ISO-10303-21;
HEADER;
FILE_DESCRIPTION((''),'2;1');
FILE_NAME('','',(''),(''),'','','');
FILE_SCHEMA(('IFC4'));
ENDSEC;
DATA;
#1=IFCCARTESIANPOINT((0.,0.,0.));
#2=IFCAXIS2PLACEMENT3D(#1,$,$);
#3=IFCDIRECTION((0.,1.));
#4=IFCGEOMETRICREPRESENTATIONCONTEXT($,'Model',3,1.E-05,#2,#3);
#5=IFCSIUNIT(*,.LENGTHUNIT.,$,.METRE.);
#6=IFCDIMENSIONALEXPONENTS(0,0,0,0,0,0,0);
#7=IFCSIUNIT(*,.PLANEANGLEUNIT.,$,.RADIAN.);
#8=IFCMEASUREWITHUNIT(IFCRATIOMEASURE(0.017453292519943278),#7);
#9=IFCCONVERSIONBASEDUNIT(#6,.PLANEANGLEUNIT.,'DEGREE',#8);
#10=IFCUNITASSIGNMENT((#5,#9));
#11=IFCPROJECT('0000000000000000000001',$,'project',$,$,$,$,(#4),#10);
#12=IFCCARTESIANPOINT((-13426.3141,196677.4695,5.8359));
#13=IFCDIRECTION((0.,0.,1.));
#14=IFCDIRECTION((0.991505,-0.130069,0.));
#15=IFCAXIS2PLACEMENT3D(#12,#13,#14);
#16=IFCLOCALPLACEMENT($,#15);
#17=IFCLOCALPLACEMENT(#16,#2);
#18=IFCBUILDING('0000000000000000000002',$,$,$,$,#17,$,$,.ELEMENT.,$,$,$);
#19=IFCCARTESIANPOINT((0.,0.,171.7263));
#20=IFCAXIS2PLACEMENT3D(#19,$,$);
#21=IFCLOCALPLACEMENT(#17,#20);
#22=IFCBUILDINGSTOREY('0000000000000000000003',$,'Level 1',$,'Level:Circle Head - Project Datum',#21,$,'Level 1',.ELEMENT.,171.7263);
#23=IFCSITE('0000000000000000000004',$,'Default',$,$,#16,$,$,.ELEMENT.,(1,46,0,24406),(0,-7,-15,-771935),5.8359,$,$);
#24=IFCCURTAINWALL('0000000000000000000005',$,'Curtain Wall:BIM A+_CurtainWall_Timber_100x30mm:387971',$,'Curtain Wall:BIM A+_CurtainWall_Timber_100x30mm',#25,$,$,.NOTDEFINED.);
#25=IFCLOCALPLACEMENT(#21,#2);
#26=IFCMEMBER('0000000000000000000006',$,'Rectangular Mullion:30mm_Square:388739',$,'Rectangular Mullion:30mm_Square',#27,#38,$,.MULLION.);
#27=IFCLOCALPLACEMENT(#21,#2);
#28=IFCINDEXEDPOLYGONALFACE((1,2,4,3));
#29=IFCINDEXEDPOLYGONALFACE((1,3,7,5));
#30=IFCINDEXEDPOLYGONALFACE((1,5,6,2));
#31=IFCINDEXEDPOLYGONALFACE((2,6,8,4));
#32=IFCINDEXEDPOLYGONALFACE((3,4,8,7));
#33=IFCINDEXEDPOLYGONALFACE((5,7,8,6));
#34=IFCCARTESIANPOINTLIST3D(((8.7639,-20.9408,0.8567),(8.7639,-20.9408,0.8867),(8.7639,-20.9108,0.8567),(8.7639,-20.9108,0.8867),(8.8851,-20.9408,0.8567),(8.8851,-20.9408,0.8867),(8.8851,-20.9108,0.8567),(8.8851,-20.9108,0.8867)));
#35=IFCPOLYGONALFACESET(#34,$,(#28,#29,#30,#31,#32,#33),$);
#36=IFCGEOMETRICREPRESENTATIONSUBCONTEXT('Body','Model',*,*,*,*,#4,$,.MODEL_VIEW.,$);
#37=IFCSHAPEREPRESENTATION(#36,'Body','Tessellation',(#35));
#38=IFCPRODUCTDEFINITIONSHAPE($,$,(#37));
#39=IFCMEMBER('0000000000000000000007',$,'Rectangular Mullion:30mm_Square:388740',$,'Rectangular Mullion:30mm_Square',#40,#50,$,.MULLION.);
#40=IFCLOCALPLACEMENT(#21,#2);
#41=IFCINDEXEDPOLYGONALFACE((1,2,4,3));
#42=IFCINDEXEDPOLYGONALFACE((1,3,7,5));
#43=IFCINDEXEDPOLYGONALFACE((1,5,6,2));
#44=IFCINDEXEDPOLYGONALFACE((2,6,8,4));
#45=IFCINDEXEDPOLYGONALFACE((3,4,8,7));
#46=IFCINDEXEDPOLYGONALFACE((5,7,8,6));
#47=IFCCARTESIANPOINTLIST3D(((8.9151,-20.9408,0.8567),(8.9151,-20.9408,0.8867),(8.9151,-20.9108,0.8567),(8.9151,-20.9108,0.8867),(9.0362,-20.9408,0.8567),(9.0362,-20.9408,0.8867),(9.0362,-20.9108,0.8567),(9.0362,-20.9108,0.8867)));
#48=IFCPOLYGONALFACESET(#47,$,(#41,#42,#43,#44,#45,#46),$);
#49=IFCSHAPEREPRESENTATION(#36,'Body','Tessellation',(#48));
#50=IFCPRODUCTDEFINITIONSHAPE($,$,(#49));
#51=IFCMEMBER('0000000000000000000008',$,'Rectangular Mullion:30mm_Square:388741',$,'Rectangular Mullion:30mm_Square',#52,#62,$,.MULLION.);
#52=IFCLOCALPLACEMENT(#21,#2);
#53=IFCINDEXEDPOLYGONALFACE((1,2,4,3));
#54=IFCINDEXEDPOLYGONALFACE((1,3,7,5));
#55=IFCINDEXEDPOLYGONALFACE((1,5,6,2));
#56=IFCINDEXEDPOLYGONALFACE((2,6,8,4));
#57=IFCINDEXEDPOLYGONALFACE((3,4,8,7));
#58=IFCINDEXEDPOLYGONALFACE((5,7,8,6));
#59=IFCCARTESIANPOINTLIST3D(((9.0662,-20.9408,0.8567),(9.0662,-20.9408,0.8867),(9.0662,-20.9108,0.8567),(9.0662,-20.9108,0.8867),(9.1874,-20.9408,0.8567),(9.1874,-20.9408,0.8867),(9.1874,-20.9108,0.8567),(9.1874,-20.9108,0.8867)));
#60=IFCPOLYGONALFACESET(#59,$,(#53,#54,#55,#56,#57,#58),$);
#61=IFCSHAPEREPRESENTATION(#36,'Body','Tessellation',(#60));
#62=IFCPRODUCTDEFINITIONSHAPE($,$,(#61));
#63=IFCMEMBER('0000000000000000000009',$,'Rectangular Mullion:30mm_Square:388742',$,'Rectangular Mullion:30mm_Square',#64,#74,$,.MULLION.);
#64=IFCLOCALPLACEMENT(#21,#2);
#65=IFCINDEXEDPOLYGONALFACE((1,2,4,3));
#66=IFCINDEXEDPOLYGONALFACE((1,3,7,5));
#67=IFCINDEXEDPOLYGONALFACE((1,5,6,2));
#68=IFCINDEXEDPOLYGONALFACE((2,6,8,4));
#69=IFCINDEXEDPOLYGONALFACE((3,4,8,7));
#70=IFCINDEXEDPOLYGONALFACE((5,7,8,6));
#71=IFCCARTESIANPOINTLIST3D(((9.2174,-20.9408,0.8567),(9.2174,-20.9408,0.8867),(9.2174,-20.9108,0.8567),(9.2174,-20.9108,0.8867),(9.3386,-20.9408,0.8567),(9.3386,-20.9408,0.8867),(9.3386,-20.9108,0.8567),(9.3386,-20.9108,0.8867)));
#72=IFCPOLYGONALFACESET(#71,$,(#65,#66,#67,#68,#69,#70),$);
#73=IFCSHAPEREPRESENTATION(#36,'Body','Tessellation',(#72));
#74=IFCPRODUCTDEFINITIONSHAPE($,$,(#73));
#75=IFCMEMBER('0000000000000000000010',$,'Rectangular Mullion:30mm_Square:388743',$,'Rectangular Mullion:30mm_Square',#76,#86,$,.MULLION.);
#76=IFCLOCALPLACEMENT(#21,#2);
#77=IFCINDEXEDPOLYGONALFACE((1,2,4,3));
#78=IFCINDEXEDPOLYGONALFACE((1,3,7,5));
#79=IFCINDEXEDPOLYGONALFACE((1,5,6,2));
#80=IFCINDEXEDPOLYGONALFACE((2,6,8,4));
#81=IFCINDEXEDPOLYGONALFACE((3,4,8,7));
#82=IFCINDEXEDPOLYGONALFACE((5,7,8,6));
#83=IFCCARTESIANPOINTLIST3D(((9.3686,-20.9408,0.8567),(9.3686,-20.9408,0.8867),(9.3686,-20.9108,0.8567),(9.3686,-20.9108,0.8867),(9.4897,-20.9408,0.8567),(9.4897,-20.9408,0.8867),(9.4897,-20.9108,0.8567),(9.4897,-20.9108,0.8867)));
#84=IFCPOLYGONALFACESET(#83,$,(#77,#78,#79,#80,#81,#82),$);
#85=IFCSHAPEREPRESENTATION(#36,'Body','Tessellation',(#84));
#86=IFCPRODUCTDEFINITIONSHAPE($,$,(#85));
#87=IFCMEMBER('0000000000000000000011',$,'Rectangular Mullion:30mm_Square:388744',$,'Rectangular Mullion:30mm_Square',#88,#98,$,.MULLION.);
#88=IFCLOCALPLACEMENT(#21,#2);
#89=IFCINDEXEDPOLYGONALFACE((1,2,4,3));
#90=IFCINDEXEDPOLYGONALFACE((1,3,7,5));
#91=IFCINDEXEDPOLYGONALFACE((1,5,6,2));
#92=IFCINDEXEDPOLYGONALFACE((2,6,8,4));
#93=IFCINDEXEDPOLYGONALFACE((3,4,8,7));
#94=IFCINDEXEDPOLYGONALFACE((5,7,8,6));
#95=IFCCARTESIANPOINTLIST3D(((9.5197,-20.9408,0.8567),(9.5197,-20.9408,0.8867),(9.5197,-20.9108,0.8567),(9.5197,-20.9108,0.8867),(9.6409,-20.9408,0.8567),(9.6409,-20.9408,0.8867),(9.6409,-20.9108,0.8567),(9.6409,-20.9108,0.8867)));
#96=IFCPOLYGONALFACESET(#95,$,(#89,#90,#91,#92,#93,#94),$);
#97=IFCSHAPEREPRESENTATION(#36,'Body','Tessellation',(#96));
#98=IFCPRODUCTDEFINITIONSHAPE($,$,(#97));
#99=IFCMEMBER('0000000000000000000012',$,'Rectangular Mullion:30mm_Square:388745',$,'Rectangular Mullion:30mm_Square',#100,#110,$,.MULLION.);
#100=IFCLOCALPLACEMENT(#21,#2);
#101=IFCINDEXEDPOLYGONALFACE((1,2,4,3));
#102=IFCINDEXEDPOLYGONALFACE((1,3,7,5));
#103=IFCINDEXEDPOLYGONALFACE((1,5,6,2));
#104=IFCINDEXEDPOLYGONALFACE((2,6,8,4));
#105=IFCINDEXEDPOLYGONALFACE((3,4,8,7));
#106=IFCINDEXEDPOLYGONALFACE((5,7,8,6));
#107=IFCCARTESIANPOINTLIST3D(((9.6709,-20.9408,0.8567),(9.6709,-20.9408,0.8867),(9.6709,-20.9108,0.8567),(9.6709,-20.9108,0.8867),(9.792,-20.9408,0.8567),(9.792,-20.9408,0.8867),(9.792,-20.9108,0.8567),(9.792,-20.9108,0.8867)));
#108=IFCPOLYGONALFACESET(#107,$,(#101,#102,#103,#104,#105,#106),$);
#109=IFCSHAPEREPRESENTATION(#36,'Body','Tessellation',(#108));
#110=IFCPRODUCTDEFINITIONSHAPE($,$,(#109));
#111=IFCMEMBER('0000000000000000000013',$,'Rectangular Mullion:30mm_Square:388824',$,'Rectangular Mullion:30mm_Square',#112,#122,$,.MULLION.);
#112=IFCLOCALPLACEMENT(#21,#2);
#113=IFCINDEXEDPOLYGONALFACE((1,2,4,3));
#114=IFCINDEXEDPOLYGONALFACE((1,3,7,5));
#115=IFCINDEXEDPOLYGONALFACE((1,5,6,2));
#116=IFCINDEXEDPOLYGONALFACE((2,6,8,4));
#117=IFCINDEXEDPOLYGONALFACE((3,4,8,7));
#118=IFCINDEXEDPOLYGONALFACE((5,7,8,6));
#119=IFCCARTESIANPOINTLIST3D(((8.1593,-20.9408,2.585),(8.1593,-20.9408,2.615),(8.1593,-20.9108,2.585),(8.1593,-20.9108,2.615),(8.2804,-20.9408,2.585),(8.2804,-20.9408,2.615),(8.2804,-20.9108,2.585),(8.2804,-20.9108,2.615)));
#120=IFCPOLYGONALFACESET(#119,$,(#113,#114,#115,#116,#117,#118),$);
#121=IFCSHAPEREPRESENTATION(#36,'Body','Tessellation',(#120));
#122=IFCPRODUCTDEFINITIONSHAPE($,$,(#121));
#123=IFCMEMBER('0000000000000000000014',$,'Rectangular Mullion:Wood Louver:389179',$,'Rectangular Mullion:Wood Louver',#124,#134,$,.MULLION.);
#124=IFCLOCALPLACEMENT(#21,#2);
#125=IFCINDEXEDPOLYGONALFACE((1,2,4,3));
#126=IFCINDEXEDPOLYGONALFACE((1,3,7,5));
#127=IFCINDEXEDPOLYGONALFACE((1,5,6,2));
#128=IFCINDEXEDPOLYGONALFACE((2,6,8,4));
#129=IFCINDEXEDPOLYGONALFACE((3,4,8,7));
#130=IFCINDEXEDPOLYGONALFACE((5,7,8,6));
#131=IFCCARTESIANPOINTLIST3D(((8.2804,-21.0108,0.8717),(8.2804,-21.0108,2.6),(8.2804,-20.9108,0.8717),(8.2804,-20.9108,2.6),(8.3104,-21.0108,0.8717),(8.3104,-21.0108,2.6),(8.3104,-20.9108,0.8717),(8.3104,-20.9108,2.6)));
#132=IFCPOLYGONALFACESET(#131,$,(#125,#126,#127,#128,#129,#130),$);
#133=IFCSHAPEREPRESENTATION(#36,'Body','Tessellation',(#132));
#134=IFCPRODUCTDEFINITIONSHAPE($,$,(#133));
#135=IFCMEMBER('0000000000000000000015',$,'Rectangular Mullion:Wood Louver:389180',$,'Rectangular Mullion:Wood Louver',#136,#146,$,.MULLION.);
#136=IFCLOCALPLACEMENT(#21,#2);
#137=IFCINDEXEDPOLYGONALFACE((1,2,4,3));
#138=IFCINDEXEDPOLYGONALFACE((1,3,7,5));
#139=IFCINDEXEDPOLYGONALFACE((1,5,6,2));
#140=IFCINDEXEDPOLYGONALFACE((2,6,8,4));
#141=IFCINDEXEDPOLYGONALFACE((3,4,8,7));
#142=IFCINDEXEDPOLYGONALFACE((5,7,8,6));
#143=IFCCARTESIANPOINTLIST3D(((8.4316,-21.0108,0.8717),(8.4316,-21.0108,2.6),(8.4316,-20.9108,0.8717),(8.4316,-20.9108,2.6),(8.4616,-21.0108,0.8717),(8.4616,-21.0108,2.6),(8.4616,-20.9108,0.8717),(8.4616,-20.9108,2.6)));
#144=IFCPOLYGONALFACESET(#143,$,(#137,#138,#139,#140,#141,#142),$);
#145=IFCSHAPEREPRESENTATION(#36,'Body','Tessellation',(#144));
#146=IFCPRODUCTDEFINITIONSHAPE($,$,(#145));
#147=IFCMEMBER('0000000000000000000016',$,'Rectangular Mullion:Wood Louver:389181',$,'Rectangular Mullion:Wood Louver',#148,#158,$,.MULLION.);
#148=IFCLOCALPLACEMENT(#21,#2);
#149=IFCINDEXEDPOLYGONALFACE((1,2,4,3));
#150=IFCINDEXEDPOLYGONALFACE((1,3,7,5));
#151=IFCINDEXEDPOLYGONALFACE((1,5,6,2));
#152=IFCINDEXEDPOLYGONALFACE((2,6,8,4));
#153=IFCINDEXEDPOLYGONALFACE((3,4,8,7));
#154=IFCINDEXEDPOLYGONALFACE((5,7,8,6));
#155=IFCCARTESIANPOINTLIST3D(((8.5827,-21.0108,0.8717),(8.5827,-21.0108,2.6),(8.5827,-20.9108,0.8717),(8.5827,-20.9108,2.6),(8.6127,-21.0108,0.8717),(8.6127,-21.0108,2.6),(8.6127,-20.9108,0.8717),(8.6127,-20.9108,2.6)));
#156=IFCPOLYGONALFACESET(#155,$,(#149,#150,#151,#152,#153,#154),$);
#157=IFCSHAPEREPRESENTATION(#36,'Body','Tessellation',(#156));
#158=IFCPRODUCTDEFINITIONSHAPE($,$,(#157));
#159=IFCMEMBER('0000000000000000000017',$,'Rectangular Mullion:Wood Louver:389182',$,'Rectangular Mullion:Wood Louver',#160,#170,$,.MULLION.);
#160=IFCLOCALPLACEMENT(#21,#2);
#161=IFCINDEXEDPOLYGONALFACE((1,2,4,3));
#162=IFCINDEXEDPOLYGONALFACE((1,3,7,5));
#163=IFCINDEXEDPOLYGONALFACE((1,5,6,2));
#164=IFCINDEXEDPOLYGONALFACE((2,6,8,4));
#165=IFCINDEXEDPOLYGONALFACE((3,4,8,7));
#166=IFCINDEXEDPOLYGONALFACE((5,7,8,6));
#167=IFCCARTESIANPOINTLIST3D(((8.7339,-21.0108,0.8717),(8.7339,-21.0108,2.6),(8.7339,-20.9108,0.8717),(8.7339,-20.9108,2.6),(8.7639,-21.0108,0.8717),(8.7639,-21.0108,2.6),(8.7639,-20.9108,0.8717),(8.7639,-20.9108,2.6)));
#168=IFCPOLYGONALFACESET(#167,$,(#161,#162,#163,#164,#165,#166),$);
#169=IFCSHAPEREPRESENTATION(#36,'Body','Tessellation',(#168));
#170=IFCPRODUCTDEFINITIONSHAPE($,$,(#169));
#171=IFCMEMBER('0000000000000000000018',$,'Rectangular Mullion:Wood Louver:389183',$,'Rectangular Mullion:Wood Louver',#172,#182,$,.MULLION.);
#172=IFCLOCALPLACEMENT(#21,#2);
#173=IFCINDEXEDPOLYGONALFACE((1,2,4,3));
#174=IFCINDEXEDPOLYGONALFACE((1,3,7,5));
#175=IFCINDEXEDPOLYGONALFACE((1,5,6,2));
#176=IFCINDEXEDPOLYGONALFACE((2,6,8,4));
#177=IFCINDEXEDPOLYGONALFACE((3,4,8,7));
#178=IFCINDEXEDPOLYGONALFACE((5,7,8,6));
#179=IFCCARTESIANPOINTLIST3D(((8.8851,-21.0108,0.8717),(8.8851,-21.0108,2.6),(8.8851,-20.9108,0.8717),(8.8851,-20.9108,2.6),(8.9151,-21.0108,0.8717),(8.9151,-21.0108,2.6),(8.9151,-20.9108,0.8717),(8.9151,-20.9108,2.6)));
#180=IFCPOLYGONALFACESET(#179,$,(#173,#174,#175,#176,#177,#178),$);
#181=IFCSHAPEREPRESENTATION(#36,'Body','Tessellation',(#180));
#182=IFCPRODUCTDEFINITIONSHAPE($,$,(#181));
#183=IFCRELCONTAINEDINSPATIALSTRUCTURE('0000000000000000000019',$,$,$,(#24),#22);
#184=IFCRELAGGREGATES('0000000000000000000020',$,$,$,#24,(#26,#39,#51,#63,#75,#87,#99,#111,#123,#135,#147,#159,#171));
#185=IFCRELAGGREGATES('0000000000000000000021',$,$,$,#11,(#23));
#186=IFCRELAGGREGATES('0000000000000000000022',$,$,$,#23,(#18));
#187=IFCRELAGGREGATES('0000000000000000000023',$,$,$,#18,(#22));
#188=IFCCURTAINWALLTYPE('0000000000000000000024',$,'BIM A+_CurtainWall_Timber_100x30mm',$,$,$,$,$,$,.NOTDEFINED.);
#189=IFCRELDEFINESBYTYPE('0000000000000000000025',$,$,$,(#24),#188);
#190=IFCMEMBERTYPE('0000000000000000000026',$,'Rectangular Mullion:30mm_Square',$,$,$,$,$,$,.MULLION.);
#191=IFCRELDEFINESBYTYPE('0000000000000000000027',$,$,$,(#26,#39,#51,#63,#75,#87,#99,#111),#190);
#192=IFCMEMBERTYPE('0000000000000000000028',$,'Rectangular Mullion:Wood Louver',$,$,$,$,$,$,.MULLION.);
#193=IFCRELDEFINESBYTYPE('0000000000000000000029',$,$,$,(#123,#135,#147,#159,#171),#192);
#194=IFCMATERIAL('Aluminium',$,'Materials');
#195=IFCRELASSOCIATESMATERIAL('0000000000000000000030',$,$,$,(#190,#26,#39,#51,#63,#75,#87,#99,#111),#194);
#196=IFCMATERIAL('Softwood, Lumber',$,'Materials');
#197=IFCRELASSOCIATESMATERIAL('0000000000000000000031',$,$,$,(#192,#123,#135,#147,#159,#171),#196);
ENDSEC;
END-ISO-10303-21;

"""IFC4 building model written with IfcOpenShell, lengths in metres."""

from ifc_helpers import new_model, entity, si_unit, converted_unit, direction, frame, origin, place, context, subcontext, project, spatial, indexed_curve, outline, extrude, source, transform, mapped, material, type_object, type_shapes, element, aggregate, save


model = new_model("IFC4")

# Units and contexts
model_context = context("Model", 3, precision=1e-05, world=origin(), true_north=direction((0.0, 1.0)))
body_context = subcontext(model_context, "Body", "Model", "MODEL_VIEW")
ifc_project = project(units=[si_unit("LENGTHUNIT", "METRE"), converted_unit("PLANEANGLEUNIT", "DEGREE", entity("IfcRatioMeasure", 0.017453292519943278), si_unit("PLANEANGLEUNIT", "RADIAN"), dimensions=[0, 0, 0, 0, 0, 0, 0])], contexts=[model_context])

# Site, building, storey
site_placement = place(None, frame((-13426.3141, 196677.4695, 5.8359), z_axis=(0.0, 0.0, 1.0), x_axis=(0.991505, -0.130069, 0.0)))
site = spatial("IfcSite", under=ifc_project, at=site_placement, Name="Default", CompositionType="ELEMENT", RefLatitude=(1, 46, 0, 24406), RefLongitude=(0, -7, -15, -771935), RefElevation=5.8359)
building_placement = place(site_placement, origin())
building = spatial("IfcBuilding", under=site, at=building_placement, CompositionType="ELEMENT")
storey_placement = place(building_placement, frame((0.0, 0.0, 171.7263)))
storey = spatial("IfcBuildingStorey", under=building, at=storey_placement, Name="Level 1", ObjectType="Level:Circle Head - Project Datum", LongName="Level 1", CompositionType="ELEMENT", Elevation=171.7263)

# Shared definitions
ifc_material_1 = material(Name="Aluminium", Category="Materials")

# Curtain wall, members
curtain_wall_type_1 = type_object("IfcCurtainWallType", Name="BIM A+_CurtainWall_Timber_100x30mm", PredefinedType="NOTDEFINED")
curtain_wall_1_placement = place(storey_placement, frame((0.0, 0.0, -171.7263)))
curtain_wall_1 = element("IfcCurtainWall", 1, at=curtain_wall_1_placement, inside=storey, type_object=curtain_wall_type_1, Name="Curtain Wall:BIM A+_CurtainWall_Timber_100x30mm:387971", ObjectType="Curtain Wall:BIM A+_CurtainWall_Timber_100x30mm", PredefinedType="NOTDEFINED")
member_type_1 = type_object("IfcMemberType", Name="Rectangular Mullion:30mm_Square", PredefinedType="MULLION", material=ifc_material_1)
shared_shape_1 = source(origin(), body_context, "Body", "SweptSolid", [
    extrude(outline(indexed_curve([(-0.015, -0.015), (0.015, -0.015), (0.015, 0.015), (-0.015, 0.015), (-0.015, -0.015)], self_intersect=False)), frame((0.0, 0.0, -0.1212), z_axis=(0.0, 0.0, 1.0), x_axis=(0.0, -1.0, 0.0)), (0.0, 0.0, 1.0), 0.1212),
])
type_shapes(member_type_1, [shared_shape_1])
member_1_placement = place(curtain_wall_1_placement, frame((8.8851, -20.9258, 172.598), z_axis=(1.0, 0.0, 0.0), x_axis=(0.0, 0.0, 1.0)))
member_1 = element("IfcMember", 2, at=member_1_placement, type_object=member_type_1, material=ifc_material_1, Name="Rectangular Mullion:30mm_Square:388739", ObjectType="Rectangular Mullion:30mm_Square", PredefinedType="MULLION", context=body_context, shape_type="MappedRepresentation", body=[
    mapped(shared_shape_1, transform((0.0, 0.0, 0.0), scale=1.0)),
])
member_2_placement = place(curtain_wall_1_placement, frame((9.0362, -20.9258, 172.598), z_axis=(1.0, 0.0, 0.0), x_axis=(0.0, 0.0, 1.0)))
member_2 = element("IfcMember", 3, at=member_2_placement, type_object=member_type_1, material=ifc_material_1, Name="Rectangular Mullion:30mm_Square:388740", ObjectType="Rectangular Mullion:30mm_Square", PredefinedType="MULLION", context=body_context, shape_type="MappedRepresentation", body=[
    mapped(shared_shape_1, transform((0.0, 0.0, 0.0), scale=1.0)),
])
member_3_placement = place(curtain_wall_1_placement, frame((9.1874, -20.9258, 172.598), z_axis=(1.0, 0.0, 0.0), x_axis=(0.0, 0.0, 1.0)))
member_3 = element("IfcMember", 4, at=member_3_placement, type_object=member_type_1, material=ifc_material_1, Name="Rectangular Mullion:30mm_Square:388741", ObjectType="Rectangular Mullion:30mm_Square", PredefinedType="MULLION", context=body_context, shape_type="MappedRepresentation", body=[
    mapped(shared_shape_1, transform((0.0, 0.0, 0.0), scale=1.0)),
])
member_4_placement = place(curtain_wall_1_placement, frame((9.3386, -20.9258, 172.598), z_axis=(1.0, 0.0, 0.0), x_axis=(0.0, 0.0, 1.0)))
member_4 = element("IfcMember", 5, at=member_4_placement, type_object=member_type_1, material=ifc_material_1, Name="Rectangular Mullion:30mm_Square:388742", ObjectType="Rectangular Mullion:30mm_Square", PredefinedType="MULLION", context=body_context, shape_type="MappedRepresentation", body=[
    mapped(shared_shape_1, transform((0.0, 0.0, 0.0), scale=1.0)),
])
member_5_placement = place(curtain_wall_1_placement, frame((9.4897, -20.9258, 172.598), z_axis=(1.0, 0.0, 0.0), x_axis=(0.0, 0.0, 1.0)))
member_5 = element("IfcMember", 6, at=member_5_placement, type_object=member_type_1, material=ifc_material_1, Name="Rectangular Mullion:30mm_Square:388743", ObjectType="Rectangular Mullion:30mm_Square", PredefinedType="MULLION", context=body_context, shape_type="MappedRepresentation", body=[
    mapped(shared_shape_1, transform((0.0, 0.0, 0.0), scale=1.0)),
])
member_6_placement = place(curtain_wall_1_placement, frame((9.6409, -20.9258, 172.598), z_axis=(1.0, 0.0, 0.0), x_axis=(0.0, 0.0, 1.0)))
member_6 = element("IfcMember", 7, at=member_6_placement, type_object=member_type_1, material=ifc_material_1, Name="Rectangular Mullion:30mm_Square:388744", ObjectType="Rectangular Mullion:30mm_Square", PredefinedType="MULLION", context=body_context, shape_type="MappedRepresentation", body=[
    mapped(shared_shape_1, transform((0.0, 0.0, 0.0), scale=1.0)),
])
member_7_placement = place(curtain_wall_1_placement, frame((9.792, -20.9258, 172.598), z_axis=(1.0, 0.0, 0.0), x_axis=(0.0, 0.0, 1.0)))
member_7 = element("IfcMember", 8, at=member_7_placement, type_object=member_type_1, material=ifc_material_1, Name="Rectangular Mullion:30mm_Square:388745", ObjectType="Rectangular Mullion:30mm_Square", PredefinedType="MULLION", context=body_context, shape_type="MappedRepresentation", body=[
    mapped(shared_shape_1, transform((0.0, 0.0, 0.0), scale=1.0)),
])
member_8_placement = place(curtain_wall_1_placement, frame((8.2804, -20.9258, 174.3263), z_axis=(1.0, 0.0, 0.0), x_axis=(0.0, 0.0, 1.0)))
member_8 = element("IfcMember", 9, at=member_8_placement, type_object=member_type_1, material=ifc_material_1, Name="Rectangular Mullion:30mm_Square:388824", ObjectType="Rectangular Mullion:30mm_Square", PredefinedType="MULLION", context=body_context, shape_type="MappedRepresentation", body=[
    mapped(shared_shape_1, transform((0.0, 0.0, 0.0), scale=1.0)),
])
ifc_material_2 = material(Name="Softwood, Lumber", Category="Materials")
member_type_2 = type_object("IfcMemberType", Name="Rectangular Mullion:Wood Louver", PredefinedType="MULLION", material=ifc_material_2)
shared_shape_2 = source(origin(), body_context, "Body", "SweptSolid", [
    extrude(outline(indexed_curve([(-0.05, -0.015), (0.05, -0.015), (0.05, 0.015), (-0.05, 0.015), (-0.05, -0.015)], self_intersect=False)), frame((0.0, 0.035, -1.7283), z_axis=(0.0, 0.0, 1.0), x_axis=(0.0, -1.0, 0.0)), (0.0, 0.0, 1.0), 1.7283),
])
type_shapes(member_type_2, [shared_shape_2])
member_9_placement = place(curtain_wall_1_placement, frame((8.2954, -20.9258, 172.598), z_axis=(0.0, 0.0, -1.0), x_axis=(1.0, 0.0, 0.0)))
member_9 = element("IfcMember", 10, at=member_9_placement, type_object=member_type_2, material=ifc_material_2, Name="Rectangular Mullion:Wood Louver:389179", ObjectType="Rectangular Mullion:Wood Louver", PredefinedType="MULLION", context=body_context, shape_type="MappedRepresentation", body=[
    mapped(shared_shape_2, transform((0.0, 0.0, 0.0), scale=1.0)),
])
member_10_placement = place(curtain_wall_1_placement, frame((8.4466, -20.9258, 172.598), z_axis=(0.0, 0.0, -1.0), x_axis=(1.0, 0.0, 0.0)))
member_10 = element("IfcMember", 11, at=member_10_placement, type_object=member_type_2, material=ifc_material_2, Name="Rectangular Mullion:Wood Louver:389180", ObjectType="Rectangular Mullion:Wood Louver", PredefinedType="MULLION", context=body_context, shape_type="MappedRepresentation", body=[
    mapped(shared_shape_2, transform((0.0, 0.0, 0.0), scale=1.0)),
])
member_11_placement = place(curtain_wall_1_placement, frame((8.5977, -20.9258, 172.598), z_axis=(0.0, 0.0, -1.0), x_axis=(1.0, 0.0, 0.0)))
member_11 = element("IfcMember", 12, at=member_11_placement, type_object=member_type_2, material=ifc_material_2, Name="Rectangular Mullion:Wood Louver:389181", ObjectType="Rectangular Mullion:Wood Louver", PredefinedType="MULLION", context=body_context, shape_type="MappedRepresentation", body=[
    mapped(shared_shape_2, transform((0.0, 0.0, 0.0), scale=1.0)),
])
member_12_placement = place(curtain_wall_1_placement, frame((8.7489, -20.9258, 172.598), z_axis=(0.0, 0.0, -1.0), x_axis=(1.0, 0.0, 0.0)))
member_12 = element("IfcMember", 13, at=member_12_placement, type_object=member_type_2, material=ifc_material_2, Name="Rectangular Mullion:Wood Louver:389182", ObjectType="Rectangular Mullion:Wood Louver", PredefinedType="MULLION", context=body_context, shape_type="MappedRepresentation", body=[
    mapped(shared_shape_2, transform((0.0, 0.0, 0.0), scale=1.0)),
])
member_13_placement = place(curtain_wall_1_placement, frame((8.9001, -20.9258, 172.598), z_axis=(0.0, 0.0, -1.0), x_axis=(1.0, 0.0, 0.0)))
member_13 = element("IfcMember", 14, at=member_13_placement, type_object=member_type_2, material=ifc_material_2, Name="Rectangular Mullion:Wood Louver:389183", ObjectType="Rectangular Mullion:Wood Louver", PredefinedType="MULLION", context=body_context, shape_type="MappedRepresentation", body=[
    mapped(shared_shape_2, transform((0.0, 0.0, 0.0), scale=1.0)),
])

aggregate(curtain_wall_1, [member_1, member_2, member_3, member_4, member_5, member_6, member_7, member_8, member_9, member_10, member_11, member_12, member_13])

save(model, "model.ifc")
